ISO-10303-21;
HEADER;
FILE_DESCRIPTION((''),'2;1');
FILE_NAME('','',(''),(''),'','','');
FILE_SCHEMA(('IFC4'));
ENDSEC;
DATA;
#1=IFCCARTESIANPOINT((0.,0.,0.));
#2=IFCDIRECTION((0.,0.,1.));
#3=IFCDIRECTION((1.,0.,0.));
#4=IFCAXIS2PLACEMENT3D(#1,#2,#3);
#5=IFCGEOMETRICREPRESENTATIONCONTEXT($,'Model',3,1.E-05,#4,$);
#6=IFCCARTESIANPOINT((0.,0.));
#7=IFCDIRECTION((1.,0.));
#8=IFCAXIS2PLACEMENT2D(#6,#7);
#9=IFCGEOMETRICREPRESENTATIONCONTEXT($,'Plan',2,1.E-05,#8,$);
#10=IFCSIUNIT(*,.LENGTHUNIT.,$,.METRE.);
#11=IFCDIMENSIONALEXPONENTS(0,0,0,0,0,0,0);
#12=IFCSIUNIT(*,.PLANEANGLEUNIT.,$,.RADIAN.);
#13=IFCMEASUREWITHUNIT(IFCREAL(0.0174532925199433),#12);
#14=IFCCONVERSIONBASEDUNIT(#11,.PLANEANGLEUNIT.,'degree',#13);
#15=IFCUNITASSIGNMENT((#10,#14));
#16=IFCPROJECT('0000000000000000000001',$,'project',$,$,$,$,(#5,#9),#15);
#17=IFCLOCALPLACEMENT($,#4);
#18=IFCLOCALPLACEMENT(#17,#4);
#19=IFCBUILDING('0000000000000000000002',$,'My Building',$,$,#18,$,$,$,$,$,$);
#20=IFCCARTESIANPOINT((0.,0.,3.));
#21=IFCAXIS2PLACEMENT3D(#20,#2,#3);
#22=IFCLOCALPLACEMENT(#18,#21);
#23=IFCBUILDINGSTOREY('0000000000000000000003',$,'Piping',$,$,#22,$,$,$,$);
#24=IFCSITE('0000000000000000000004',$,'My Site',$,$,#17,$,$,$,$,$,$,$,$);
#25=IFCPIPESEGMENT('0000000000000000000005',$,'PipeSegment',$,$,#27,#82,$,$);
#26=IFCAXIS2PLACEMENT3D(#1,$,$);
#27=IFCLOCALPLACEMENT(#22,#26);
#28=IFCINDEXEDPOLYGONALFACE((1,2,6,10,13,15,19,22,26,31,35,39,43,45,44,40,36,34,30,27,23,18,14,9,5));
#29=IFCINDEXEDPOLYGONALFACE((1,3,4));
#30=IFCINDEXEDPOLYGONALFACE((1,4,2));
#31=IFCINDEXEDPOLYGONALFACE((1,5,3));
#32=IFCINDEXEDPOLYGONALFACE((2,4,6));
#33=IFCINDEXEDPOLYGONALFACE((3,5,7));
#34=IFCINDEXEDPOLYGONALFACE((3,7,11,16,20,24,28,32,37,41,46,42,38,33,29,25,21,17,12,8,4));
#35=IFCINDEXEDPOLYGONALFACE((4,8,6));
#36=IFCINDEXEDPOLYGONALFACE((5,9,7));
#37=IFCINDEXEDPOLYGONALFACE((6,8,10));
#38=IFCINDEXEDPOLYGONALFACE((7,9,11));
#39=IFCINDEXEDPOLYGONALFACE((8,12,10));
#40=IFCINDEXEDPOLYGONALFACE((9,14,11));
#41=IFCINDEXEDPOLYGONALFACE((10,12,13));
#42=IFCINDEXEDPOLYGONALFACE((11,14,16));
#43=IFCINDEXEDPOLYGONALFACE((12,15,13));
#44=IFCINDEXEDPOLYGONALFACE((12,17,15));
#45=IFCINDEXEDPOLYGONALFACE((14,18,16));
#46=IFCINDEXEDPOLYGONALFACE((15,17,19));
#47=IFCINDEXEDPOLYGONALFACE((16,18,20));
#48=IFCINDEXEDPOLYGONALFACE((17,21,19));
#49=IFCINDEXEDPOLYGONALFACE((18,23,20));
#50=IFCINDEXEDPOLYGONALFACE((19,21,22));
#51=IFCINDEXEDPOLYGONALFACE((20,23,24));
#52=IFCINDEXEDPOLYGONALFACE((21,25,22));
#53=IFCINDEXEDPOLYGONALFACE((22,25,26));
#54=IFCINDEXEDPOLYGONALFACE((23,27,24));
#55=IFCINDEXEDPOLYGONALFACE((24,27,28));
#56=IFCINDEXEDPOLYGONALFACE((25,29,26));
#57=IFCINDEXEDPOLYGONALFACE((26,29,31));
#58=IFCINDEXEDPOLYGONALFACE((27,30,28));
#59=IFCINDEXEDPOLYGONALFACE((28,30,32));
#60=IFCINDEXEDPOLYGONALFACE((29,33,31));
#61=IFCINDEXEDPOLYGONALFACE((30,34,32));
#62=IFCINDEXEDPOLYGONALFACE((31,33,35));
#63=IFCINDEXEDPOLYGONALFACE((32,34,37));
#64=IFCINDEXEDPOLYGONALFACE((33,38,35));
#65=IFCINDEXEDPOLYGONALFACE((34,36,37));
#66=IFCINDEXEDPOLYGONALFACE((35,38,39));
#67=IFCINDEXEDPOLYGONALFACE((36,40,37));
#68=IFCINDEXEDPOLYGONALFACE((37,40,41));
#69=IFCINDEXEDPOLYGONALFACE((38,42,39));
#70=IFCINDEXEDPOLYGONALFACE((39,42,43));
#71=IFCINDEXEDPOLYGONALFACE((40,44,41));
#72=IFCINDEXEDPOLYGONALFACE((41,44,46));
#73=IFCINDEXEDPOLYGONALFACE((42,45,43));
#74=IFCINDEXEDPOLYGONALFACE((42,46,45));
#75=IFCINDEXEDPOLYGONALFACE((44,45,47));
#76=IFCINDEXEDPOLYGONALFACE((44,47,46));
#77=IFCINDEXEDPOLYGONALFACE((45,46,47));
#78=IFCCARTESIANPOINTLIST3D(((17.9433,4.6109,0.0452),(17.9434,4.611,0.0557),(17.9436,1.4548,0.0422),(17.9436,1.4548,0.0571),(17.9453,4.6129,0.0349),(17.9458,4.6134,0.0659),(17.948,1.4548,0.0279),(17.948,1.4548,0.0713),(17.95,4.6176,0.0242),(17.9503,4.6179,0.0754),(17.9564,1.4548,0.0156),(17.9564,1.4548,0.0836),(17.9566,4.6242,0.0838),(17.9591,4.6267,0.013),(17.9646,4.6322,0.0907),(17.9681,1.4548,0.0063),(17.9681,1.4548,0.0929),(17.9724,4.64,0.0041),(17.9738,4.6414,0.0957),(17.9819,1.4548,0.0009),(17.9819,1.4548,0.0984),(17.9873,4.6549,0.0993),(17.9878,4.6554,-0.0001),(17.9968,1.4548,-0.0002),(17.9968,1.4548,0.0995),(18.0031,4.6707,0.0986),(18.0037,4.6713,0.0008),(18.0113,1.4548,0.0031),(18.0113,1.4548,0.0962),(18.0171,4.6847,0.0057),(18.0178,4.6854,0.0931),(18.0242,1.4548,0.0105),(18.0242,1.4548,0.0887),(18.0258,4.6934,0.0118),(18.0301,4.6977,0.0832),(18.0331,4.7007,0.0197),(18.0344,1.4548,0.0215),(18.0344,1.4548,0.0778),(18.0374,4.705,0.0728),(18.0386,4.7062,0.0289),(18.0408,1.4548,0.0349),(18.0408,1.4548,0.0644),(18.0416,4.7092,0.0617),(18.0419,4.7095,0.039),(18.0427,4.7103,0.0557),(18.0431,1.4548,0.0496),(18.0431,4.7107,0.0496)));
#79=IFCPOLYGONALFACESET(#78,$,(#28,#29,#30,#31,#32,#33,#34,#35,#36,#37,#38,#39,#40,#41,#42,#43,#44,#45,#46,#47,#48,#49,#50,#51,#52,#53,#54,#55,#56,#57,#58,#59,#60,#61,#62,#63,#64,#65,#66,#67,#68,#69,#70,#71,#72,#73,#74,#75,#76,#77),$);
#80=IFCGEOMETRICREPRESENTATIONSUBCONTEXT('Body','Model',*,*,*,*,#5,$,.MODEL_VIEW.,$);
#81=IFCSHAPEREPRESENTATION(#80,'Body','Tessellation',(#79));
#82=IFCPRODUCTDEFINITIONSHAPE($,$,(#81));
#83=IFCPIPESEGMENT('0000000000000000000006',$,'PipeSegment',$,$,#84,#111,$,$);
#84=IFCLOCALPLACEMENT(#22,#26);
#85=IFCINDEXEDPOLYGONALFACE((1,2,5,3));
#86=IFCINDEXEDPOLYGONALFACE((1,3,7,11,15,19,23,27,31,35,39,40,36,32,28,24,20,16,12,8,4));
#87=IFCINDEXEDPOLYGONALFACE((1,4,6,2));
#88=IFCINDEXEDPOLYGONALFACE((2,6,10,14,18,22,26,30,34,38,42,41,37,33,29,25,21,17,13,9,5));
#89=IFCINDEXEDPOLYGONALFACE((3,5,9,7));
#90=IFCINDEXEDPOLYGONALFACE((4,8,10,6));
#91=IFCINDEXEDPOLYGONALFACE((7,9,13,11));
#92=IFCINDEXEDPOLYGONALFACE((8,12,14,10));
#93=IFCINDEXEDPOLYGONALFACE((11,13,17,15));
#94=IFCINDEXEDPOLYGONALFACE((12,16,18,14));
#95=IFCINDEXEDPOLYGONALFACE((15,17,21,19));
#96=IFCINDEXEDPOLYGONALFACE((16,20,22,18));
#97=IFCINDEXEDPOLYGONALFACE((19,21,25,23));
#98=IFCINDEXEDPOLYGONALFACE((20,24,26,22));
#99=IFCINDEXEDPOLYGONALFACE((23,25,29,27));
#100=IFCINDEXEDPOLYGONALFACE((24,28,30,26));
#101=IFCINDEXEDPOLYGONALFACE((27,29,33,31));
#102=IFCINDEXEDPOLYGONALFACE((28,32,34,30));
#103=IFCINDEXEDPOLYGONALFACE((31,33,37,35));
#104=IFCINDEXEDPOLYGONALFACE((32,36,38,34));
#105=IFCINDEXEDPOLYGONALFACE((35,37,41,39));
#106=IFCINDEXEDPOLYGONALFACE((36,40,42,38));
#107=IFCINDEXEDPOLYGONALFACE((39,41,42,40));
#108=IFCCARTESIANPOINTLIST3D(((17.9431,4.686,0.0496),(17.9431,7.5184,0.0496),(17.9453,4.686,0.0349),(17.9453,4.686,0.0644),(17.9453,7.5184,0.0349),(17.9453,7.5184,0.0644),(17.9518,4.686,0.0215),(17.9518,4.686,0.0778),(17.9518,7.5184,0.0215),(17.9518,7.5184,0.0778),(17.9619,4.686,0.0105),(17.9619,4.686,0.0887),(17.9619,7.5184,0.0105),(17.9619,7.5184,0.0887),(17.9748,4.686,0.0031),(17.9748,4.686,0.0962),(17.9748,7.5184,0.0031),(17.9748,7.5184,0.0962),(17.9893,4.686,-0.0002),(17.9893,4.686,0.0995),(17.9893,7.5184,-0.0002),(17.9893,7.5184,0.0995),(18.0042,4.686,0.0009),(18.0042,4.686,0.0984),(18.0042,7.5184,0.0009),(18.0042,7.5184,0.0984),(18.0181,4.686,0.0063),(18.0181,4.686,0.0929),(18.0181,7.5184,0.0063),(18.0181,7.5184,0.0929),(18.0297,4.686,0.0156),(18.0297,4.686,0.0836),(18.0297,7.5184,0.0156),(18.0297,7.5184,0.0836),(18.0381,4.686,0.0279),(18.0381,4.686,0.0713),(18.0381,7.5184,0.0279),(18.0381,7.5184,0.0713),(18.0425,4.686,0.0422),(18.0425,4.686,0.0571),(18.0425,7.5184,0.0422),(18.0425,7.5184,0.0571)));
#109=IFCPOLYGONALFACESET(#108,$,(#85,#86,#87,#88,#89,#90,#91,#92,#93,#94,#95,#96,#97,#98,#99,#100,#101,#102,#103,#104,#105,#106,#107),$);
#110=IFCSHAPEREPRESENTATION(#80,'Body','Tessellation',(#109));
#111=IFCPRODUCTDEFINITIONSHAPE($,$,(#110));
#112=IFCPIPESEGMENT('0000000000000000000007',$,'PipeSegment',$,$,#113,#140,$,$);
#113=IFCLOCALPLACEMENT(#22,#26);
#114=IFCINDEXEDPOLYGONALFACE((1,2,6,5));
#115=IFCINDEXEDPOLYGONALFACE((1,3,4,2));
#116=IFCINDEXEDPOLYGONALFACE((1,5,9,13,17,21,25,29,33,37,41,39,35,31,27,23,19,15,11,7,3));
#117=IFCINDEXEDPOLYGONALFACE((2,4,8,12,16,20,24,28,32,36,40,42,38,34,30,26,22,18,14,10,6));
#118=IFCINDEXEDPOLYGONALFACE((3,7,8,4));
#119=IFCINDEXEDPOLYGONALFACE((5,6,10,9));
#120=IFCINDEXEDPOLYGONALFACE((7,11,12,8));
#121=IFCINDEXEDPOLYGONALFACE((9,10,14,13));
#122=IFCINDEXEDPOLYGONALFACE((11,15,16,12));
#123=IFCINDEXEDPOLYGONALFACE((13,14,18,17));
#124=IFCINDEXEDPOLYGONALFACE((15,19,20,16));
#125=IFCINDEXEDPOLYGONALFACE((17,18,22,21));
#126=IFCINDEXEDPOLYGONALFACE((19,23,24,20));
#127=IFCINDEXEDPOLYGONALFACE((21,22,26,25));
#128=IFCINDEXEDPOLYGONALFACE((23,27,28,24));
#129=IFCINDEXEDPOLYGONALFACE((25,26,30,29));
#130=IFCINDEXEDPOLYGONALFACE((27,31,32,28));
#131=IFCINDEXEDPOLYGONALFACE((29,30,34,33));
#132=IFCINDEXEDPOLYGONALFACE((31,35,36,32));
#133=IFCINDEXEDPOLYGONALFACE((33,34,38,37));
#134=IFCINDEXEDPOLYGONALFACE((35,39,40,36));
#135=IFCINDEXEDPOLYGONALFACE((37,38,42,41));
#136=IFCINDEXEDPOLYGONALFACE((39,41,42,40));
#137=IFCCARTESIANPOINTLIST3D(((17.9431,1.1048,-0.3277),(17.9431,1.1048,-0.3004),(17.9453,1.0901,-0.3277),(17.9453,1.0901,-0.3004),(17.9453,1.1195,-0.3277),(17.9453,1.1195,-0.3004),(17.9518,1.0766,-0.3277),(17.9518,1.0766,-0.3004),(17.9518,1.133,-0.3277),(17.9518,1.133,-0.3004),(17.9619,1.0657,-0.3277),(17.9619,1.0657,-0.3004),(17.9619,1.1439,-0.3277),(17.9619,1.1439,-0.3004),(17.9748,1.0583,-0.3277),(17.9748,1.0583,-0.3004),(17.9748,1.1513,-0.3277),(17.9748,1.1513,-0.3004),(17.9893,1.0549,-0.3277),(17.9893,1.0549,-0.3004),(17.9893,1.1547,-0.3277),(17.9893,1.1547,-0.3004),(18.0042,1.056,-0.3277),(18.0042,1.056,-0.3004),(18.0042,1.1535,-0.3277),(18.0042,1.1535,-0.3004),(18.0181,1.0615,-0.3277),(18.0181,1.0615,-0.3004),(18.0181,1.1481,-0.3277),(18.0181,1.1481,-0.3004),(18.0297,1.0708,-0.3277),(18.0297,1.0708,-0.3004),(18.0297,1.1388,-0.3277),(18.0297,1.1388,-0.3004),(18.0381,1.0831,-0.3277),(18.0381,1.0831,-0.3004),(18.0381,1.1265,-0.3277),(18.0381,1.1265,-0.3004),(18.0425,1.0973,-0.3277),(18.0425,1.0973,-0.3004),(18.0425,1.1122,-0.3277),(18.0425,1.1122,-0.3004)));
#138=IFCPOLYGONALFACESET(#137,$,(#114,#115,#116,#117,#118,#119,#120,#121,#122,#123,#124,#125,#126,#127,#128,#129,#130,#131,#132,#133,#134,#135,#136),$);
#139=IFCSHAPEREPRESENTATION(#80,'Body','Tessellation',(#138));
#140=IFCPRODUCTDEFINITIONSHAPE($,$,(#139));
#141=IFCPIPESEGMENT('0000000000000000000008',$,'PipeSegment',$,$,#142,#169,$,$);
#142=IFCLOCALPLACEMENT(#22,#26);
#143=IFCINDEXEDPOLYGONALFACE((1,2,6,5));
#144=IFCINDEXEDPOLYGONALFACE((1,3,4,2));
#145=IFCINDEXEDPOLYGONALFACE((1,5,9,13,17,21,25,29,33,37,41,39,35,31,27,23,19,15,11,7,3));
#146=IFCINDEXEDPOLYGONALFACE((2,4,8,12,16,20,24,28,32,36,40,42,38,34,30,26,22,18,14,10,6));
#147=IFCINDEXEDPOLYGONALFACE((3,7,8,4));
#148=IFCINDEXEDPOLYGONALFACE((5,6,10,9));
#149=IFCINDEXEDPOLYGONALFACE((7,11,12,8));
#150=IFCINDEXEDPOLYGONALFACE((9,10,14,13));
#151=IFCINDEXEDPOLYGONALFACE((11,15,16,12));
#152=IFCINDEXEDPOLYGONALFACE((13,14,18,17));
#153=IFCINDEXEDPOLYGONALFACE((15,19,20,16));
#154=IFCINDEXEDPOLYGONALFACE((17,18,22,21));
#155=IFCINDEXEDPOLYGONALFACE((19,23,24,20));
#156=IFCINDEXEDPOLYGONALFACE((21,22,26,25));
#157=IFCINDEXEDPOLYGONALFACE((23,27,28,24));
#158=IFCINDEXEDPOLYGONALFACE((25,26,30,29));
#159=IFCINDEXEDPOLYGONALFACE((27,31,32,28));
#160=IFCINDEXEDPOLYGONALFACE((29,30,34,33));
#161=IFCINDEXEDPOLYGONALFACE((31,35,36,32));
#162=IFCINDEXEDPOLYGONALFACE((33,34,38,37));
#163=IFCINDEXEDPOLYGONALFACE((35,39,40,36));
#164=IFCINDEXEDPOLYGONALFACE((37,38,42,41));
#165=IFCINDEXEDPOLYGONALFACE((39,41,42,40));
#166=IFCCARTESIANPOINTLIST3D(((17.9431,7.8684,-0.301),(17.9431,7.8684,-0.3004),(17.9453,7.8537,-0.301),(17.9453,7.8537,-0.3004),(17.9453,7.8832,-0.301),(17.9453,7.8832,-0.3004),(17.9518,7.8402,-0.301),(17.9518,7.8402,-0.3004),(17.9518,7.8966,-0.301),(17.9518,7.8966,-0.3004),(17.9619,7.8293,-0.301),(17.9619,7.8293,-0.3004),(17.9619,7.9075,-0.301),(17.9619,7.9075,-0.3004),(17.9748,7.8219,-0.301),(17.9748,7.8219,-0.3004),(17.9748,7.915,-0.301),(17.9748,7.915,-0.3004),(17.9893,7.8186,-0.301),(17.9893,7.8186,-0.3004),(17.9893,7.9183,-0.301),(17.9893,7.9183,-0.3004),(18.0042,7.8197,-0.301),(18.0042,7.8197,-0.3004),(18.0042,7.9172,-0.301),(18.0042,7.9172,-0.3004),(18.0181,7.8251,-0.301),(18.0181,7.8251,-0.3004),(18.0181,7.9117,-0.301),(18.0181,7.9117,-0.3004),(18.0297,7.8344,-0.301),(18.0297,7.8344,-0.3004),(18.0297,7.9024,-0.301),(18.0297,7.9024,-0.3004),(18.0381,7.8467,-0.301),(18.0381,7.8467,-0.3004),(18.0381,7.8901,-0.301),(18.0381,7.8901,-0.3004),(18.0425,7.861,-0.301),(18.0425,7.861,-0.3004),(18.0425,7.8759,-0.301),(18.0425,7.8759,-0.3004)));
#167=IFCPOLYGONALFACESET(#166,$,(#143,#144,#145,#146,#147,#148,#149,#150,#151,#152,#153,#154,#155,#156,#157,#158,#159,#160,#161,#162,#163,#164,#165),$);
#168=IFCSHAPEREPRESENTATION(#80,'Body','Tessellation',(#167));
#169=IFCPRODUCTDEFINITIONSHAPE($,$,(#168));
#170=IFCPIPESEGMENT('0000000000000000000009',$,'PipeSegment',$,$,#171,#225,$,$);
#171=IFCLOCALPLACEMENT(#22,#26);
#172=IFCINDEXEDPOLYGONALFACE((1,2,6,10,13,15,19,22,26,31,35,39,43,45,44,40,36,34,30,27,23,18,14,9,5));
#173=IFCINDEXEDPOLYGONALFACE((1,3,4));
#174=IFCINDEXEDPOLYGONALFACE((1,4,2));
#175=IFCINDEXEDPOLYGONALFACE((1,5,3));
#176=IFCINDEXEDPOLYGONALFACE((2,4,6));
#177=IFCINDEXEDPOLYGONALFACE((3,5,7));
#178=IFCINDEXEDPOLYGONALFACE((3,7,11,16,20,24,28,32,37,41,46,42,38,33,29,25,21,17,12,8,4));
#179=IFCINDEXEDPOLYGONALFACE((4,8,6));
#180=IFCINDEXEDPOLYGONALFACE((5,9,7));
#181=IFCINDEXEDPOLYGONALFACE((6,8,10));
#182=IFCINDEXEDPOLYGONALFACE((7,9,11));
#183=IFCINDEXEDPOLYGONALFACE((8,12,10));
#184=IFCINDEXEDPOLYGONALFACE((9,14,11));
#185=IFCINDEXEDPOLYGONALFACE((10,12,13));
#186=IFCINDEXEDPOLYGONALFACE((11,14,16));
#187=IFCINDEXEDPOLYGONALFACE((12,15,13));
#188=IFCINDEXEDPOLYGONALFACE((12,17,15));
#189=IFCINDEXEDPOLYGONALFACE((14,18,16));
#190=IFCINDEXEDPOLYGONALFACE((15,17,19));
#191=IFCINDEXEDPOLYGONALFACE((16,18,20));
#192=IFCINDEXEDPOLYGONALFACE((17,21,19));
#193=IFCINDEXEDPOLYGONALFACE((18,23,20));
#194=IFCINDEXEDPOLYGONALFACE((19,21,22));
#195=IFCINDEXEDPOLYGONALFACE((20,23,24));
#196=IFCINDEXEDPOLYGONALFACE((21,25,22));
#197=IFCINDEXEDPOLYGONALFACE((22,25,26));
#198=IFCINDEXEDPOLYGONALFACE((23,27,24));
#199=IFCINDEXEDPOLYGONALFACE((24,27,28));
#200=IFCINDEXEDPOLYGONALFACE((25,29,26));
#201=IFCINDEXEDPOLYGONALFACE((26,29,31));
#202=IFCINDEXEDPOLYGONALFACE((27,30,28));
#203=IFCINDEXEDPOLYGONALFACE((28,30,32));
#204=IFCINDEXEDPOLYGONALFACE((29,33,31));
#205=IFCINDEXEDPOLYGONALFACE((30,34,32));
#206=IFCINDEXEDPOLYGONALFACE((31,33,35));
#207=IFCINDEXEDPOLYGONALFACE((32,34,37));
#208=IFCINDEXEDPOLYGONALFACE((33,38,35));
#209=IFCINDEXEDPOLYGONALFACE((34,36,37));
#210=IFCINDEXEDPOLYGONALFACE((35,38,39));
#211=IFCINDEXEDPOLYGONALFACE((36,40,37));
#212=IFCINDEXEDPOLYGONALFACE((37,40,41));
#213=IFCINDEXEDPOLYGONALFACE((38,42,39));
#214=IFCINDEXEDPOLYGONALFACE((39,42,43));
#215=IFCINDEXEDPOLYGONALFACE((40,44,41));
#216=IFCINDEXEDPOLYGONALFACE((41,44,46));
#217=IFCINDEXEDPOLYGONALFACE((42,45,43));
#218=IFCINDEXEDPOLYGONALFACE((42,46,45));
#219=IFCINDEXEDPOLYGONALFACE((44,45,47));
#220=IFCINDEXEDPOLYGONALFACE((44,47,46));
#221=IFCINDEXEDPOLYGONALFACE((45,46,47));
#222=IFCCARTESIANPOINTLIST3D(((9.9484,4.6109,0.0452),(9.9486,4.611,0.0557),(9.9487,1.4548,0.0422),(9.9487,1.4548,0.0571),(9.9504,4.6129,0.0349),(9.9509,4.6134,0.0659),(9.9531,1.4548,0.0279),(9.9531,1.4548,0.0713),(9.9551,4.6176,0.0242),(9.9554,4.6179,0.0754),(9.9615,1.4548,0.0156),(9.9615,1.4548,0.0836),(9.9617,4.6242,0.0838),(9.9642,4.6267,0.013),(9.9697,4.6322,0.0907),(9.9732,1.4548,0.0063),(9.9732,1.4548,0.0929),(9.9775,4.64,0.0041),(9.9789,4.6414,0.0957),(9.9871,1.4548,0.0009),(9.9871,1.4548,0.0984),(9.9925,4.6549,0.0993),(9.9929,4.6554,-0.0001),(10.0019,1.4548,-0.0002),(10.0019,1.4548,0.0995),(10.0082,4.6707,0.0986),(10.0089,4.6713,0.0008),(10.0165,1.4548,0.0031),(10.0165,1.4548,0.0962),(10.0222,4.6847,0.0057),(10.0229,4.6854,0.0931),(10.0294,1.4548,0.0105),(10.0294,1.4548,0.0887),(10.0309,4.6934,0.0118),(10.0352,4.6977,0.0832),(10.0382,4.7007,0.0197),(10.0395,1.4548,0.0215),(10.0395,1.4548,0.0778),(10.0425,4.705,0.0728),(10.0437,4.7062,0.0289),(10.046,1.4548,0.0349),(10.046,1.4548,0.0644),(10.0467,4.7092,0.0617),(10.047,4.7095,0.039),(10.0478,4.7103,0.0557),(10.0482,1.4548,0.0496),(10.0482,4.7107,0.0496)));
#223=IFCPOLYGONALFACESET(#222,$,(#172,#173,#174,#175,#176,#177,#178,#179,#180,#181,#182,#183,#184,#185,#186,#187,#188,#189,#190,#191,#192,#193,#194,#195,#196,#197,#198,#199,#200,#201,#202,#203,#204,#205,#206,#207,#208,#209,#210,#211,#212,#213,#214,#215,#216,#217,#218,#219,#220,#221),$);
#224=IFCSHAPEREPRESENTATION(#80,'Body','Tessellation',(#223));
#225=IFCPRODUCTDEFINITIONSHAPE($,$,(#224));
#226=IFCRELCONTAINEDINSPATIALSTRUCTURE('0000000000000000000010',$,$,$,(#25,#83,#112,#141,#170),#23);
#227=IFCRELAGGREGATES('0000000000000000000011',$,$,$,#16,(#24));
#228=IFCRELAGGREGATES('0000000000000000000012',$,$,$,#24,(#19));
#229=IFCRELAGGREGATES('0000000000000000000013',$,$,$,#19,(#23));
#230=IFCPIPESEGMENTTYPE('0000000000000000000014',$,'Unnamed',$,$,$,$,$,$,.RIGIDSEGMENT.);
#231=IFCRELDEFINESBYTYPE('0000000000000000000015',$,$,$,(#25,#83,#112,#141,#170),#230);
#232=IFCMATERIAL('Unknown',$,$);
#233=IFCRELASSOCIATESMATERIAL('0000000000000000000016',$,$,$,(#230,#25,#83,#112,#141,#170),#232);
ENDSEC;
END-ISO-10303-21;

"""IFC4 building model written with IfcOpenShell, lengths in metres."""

from ifc_helpers import new_model, entity, si_unit, converted_unit, frame, origin_with_axes, origin_2d_with_axis, place, context, subcontext, project, spatial, circle, extrude, clip, halfspace, material, material_profile, profile_set, profile_usage, type_object, element, save


model = new_model("IFC4")

# Units and contexts
model_context = context("Model", 3, precision=1e-05, world=origin_with_axes())
plan_context = context("Plan", 2, precision=1e-05, world=origin_2d_with_axis())
body_context = subcontext(model_context, "Body", "Model", "MODEL_VIEW")
ifc_project = project(units=[si_unit("LENGTHUNIT", "METRE"), converted_unit("PLANEANGLEUNIT", "degree", entity("IfcReal", 0.0174532925199433), si_unit("PLANEANGLEUNIT", "RADIAN"), dimensions=[0, 0, 0, 0, 0, 0, 0])], contexts=[model_context, plan_context])

# Site, building, storey
site_placement = place(None, origin_with_axes())
site = spatial("IfcSite", under=ifc_project, at=site_placement, Name="My Site")
building_placement = place(site_placement, origin_with_axes())
building = spatial("IfcBuilding", under=site, at=building_placement, Name="My Building")
storey_placement = place(building_placement, frame((0.0, 0.0, 3.0), z_axis=(0.0, 0.0, 1.0), x_axis=(1.0, 0.0, 0.0)))
storey = spatial("IfcBuildingStorey", under=building, at=storey_placement, Name="Piping")

# Pipe segments
ifc_material = material(Name="Unknown")
ifc_material_profile = material_profile(ifc_material, circle(Radius=0.05))
ifc_profile_set = profile_set([ifc_material_profile])
pipe_segment_type = type_object("IfcPipeSegmentType", Name="Unnamed", PredefinedType="RIGIDSEGMENT", material=ifc_profile_set)
ifc_profile_usage_1 = profile_usage(ifc_profile_set, cardinal=5)
pipe_segment_1_placement = place(storey_placement, frame((17.9931, 4.7107, 0.0496), z_axis=(0.0, -1.0, 0.000007), x_axis=(1.0, 0.0, 0.0)))
element("IfcPipeSegment", 1, at=pipe_segment_1_placement, inside=storey, type_object=pipe_segment_type, material=ifc_profile_usage_1, Name="PipeSegment", context=body_context, shape_type="Clipping", body=[
    clip(extrude(circle(Radius=0.05), origin_with_axes(), (0.0, 0.0, 1.0), 3.2559), halfspace(frame((0.05, -3.0496, 0.0), z_axis=(-0.707114, 0.000005, -0.7071), x_axis=(0.000007, 1.0, 0.0)), False)),
])
ifc_profile_usage_2 = profile_usage(ifc_profile_set, cardinal=5)
pipe_segment_2_placement = place(storey_placement, frame((17.9931, 4.686, 0.0496), z_axis=(0.0, 1.0, 0.0), x_axis=(-1.0, 0.0, 0.0)))
element("IfcPipeSegment", 2, at=pipe_segment_2_placement, inside=storey, type_object=pipe_segment_type, material=ifc_profile_usage_2, Name="PipeSegment", context=body_context, shape_type="SweptSolid", body=[
    extrude(circle(Radius=0.05), origin_with_axes(), (0.0, 0.0, 1.0), 2.8324),
])
ifc_profile_usage_3 = profile_usage(ifc_profile_set, cardinal=5)
pipe_segment_3_placement = place(storey_placement, frame((17.9931, 1.1048, -0.3004), z_axis=(0.0, 0.0, -1.0), x_axis=(-1.0, 0.0, 0.0)))
element("IfcPipeSegment", 3, at=pipe_segment_3_placement, inside=storey, type_object=pipe_segment_type, material=ifc_profile_usage_3, Name="PipeSegment", context=body_context, shape_type="SweptSolid", body=[
    extrude(circle(Radius=0.05), origin_with_axes(), (0.0, 0.0, 1.0), 0.0273),
])
ifc_profile_usage_4 = profile_usage(ifc_profile_set, cardinal=5)
pipe_segment_4_placement = place(storey_placement, frame((17.9931, 7.8684, -0.3004), z_axis=(0.0, 0.0, -1.0), x_axis=(-1.0, 0.0, 0.0)))
element("IfcPipeSegment", 4, at=pipe_segment_4_placement, inside=storey, type_object=pipe_segment_type, material=ifc_profile_usage_4, Name="PipeSegment", context=body_context, shape_type="SweptSolid", body=[
    extrude(circle(Radius=0.05), origin_with_axes(), (0.0, 0.0, 1.0), 0.0007),
])
ifc_profile_usage_5 = profile_usage(ifc_profile_set, cardinal=5)
pipe_segment_5_placement = place(storey_placement, frame((9.9982, 4.7107, 0.0496), z_axis=(0.0, -1.0, 0.000007), x_axis=(1.0, 0.0, 0.0)))
element("IfcPipeSegment", 5, at=pipe_segment_5_placement, inside=storey, type_object=pipe_segment_type, material=ifc_profile_usage_5, Name="PipeSegment", context=body_context, shape_type="Clipping", body=[
    clip(extrude(circle(Radius=0.05), origin_with_axes(), (0.0, 0.0, 1.0), 3.2559), halfspace(frame((0.05, -3.0496, 0.0), z_axis=(-0.707114, 0.000005, -0.7071), x_axis=(0.000007, 1.0, 0.0)), False)),
])

save(model, "model.ifc")
